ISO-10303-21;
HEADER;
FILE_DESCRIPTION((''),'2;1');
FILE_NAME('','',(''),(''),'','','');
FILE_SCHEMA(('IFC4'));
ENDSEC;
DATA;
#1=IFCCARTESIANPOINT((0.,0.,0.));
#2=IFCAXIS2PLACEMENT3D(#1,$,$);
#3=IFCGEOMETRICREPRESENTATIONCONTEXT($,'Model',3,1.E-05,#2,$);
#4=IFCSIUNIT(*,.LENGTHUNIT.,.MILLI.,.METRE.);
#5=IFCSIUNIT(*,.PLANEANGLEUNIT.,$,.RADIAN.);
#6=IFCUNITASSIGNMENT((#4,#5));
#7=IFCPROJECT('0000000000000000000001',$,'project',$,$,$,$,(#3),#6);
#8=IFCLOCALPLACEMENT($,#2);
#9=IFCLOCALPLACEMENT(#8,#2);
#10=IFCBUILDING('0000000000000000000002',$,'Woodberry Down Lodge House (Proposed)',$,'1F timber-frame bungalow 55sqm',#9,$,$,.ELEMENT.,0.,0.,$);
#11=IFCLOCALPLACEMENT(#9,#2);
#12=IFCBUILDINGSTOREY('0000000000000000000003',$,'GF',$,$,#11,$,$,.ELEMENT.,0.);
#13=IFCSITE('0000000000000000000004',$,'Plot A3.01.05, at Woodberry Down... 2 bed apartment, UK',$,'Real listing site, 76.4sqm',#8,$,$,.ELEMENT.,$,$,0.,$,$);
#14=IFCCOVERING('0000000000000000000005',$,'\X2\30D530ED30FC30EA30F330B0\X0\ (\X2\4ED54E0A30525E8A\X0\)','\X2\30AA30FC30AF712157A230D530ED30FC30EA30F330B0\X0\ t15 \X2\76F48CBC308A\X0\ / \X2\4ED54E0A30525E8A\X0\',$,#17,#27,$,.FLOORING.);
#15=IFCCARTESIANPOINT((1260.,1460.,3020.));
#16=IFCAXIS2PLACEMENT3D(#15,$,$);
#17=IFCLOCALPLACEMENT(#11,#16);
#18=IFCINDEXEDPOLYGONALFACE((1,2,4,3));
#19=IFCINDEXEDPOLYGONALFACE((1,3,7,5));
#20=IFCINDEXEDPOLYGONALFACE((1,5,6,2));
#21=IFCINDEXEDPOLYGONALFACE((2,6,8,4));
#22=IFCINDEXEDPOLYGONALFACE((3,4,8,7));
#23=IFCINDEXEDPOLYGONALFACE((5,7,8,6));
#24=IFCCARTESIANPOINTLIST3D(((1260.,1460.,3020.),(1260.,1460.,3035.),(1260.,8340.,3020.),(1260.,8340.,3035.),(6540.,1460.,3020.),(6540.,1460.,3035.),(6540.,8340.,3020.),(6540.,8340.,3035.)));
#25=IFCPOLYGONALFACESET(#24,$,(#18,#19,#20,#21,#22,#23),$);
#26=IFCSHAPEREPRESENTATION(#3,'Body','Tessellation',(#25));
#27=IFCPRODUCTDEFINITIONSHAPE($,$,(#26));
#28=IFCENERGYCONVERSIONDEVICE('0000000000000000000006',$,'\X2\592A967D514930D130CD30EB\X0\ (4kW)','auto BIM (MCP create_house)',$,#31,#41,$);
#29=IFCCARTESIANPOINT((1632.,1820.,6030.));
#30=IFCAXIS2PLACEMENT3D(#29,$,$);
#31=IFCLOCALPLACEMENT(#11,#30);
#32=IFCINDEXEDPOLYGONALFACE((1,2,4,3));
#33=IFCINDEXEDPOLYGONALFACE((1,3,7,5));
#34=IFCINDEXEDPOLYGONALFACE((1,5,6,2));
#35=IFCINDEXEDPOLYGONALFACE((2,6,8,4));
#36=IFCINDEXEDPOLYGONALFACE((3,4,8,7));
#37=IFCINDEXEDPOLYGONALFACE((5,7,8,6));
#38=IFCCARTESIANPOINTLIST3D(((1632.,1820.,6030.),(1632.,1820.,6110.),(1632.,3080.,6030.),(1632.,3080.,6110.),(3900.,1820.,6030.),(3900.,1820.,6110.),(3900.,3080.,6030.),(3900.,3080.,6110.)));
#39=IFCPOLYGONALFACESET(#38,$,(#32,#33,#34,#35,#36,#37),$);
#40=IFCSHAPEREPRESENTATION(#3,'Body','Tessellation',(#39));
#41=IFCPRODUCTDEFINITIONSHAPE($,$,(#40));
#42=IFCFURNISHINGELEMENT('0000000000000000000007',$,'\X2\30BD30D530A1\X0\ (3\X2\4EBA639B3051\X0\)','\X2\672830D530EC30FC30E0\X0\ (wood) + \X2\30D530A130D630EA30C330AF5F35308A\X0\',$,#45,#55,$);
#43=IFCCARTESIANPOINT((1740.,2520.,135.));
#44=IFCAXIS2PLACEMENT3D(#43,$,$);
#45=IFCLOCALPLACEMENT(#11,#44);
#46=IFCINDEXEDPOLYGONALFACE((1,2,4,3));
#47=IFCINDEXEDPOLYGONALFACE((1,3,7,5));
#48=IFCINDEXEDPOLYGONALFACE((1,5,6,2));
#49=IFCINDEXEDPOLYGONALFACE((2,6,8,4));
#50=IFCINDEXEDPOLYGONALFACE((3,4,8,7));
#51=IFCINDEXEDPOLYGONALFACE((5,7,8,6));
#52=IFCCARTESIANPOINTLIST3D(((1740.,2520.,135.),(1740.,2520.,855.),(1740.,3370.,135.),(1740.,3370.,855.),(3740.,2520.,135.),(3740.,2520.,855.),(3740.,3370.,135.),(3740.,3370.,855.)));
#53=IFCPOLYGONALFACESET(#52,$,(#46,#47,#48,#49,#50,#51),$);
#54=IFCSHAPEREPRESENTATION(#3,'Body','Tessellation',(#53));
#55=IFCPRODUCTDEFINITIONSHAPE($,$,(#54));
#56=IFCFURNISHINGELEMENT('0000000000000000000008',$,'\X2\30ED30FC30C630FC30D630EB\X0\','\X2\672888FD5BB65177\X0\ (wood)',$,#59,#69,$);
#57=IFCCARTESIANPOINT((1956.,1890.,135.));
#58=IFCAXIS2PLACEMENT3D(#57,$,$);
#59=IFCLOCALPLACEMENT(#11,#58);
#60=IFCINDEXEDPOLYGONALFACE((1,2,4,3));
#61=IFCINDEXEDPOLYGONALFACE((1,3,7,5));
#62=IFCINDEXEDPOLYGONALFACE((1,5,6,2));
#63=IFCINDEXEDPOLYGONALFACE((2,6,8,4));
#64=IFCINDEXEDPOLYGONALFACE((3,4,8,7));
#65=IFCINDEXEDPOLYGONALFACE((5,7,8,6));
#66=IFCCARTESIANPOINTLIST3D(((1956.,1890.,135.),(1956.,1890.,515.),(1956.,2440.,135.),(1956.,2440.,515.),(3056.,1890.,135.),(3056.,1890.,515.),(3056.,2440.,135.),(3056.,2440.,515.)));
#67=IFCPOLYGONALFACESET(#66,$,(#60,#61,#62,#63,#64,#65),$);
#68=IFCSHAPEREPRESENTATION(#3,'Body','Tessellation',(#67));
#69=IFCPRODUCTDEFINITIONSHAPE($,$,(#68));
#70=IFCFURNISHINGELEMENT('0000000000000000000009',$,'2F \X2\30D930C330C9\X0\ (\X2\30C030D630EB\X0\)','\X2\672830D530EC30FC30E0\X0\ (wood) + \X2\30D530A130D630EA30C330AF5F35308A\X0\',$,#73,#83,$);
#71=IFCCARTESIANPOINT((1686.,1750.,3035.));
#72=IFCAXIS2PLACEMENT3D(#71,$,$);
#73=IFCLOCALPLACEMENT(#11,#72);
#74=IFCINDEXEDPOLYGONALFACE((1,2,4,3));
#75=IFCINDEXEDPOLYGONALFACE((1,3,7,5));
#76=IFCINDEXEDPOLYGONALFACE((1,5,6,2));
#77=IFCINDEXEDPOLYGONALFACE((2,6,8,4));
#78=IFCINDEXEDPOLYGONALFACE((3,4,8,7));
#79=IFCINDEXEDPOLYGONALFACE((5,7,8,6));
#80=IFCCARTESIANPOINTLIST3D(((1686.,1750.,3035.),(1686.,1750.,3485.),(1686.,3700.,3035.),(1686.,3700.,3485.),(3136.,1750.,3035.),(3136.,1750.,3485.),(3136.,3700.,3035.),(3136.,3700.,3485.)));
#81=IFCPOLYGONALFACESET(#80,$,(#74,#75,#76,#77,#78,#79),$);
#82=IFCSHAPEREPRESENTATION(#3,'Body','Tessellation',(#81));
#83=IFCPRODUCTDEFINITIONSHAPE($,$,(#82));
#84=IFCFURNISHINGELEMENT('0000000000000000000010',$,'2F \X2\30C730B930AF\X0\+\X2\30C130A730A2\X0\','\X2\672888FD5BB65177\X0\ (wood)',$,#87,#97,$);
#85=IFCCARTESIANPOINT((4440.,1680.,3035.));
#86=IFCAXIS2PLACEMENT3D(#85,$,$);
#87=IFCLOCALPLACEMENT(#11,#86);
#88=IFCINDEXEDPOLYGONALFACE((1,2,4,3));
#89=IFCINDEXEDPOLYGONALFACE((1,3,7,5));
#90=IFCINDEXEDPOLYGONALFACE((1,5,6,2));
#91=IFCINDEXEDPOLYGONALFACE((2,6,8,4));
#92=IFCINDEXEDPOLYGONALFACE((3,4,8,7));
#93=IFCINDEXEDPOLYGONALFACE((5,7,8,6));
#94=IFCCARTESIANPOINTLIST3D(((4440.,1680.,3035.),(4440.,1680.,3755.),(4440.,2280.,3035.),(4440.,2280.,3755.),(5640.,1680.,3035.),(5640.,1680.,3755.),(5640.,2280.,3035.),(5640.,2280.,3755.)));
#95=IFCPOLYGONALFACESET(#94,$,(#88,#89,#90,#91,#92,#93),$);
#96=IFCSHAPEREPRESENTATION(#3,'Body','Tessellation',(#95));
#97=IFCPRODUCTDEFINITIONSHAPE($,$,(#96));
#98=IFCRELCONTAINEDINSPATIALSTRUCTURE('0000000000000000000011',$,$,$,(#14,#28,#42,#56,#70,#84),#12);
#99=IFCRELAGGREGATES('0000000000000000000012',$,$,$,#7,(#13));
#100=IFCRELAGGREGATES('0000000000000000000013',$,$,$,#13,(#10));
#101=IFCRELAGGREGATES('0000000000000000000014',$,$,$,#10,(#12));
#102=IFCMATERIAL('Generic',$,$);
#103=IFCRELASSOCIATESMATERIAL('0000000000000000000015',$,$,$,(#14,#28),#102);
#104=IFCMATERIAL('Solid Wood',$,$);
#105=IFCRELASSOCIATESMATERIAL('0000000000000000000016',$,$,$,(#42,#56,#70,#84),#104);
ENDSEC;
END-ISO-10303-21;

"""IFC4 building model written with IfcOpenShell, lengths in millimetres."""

from ifc_helpers import new_model, si_unit, frame, frame_2d, origin, place, context, project, spatial, rectangle, extrude, material, element, save


model = new_model("IFC4")

# Units and contexts
model_context = context("Model", 3, precision=1e-05, world=origin())
ifc_project = project(units=[si_unit("LENGTHUNIT", "METRE", prefix="MILLI"), si_unit("PLANEANGLEUNIT", "RADIAN")], contexts=[model_context])

# Site, building, storey
site_placement = place(None, origin())
site = spatial("IfcSite", under=ifc_project, at=site_placement, Name="Plot A3.01.05, at Woodberry Down... 2 bed apartment, UK", ObjectType="Real listing site, 76.4sqm", CompositionType="ELEMENT", RefElevation=0.0)
building_placement = place(site_placement, origin())
building = spatial("IfcBuilding", under=site, at=building_placement, Name="Woodberry Down Lodge House (Proposed)", ObjectType="1F timber-frame bungalow 55sqm", CompositionType="ELEMENT", ElevationOfRefHeight=0.0, ElevationOfTerrain=0.0)
storey_placement = place(building_placement, origin())
storey = spatial("IfcBuildingStorey", under=building, at=storey_placement, Name="GF", CompositionType="ELEMENT", Elevation=0.0)

# Shared definitions
ifc_material_1 = material(Name="Solid Wood")

# Shared definitions
ifc_material_2 = material(Name="Generic")

# Covering
covering_placement = place(storey_placement, frame((1260.0, 1460.0, 3020.0)))
element("IfcCovering", 1, at=covering_placement, inside=storey, material=ifc_material_2, Name="フローリング (仕上げ床)", Description="オーク無垢フローリング t15 直貼り / 仕上げ床", PredefinedType="FLOORING", context=model_context, shape_type="SweptSolid", body=[
    extrude(rectangle(XDim=5280.0, YDim=6880.0, at=frame_2d((2640.0, 3440.0))), frame((1260.0, 1460.0, 3020.0)), (0.0, 0.0, 1.0), 15.0),
])

# Energy conversion device
energy_conversion_device_placement = place(storey_placement, frame((1632.0, 1820.0, 6030.0)))
element("IfcEnergyConversionDevice", 2, at=energy_conversion_device_placement, inside=storey, material=ifc_material_2, Name="太陽光パネル (4kW)", Description="auto BIM (MCP create_house)", context=model_context, shape_type="SweptSolid", body=[
    extrude(rectangle(XDim=2268.0, YDim=1260.0, at=frame_2d((1134.0, 630.0))), frame((1632.0, 1820.0, 6030.0)), (0.0, 0.0, 1.0), 80.0),
])

# Furnishing elements
furnishing_1_placement = place(storey_placement, frame((1740.0, 2520.0, 135.0)))
element("IfcFurnishingElement", 3, at=furnishing_1_placement, inside=storey, material=ifc_material_1, Name="ソファ (3人掛け)", Description="木フレーム (wood) + ファブリック張り", context=model_context, shape_type="SweptSolid", body=[
    extrude(rectangle(XDim=2000.0, YDim=850.0, at=frame_2d((1000.0, 425.0))), frame((1740.0, 2520.0, 135.0)), (0.0, 0.0, 1.0), 720.0),
])
furnishing_2_placement = place(storey_placement, frame((1956.0, 1890.0, 135.0)))
element("IfcFurnishingElement", 4, at=furnishing_2_placement, inside=storey, material=ifc_material_1, Name="ローテーブル", Description="木製家具 (wood)", context=model_context, shape_type="SweptSolid", body=[
    extrude(rectangle(XDim=1100.0, YDim=550.0, at=frame_2d((550.0, 275.0))), frame((1956.0, 1890.0, 135.0)), (0.0, 0.0, 1.0), 380.0),
])
furnishing_3_placement = place(storey_placement, frame((1686.0, 1750.0, 3035.0)))
element("IfcFurnishingElement", 5, at=furnishing_3_placement, inside=storey, material=ifc_material_1, Name="2F ベッド (ダブル)", Description="木フレーム (wood) + ファブリック張り", context=model_context, shape_type="SweptSolid", body=[
    extrude(rectangle(XDim=1450.0, YDim=1950.0, at=frame_2d((725.0, 975.0))), frame((1686.0, 1750.0, 3035.0)), (0.0, 0.0, 1.0), 450.0),
])
furnishing_4_placement = place(storey_placement, frame((4440.0, 1680.0, 3035.0)))
element("IfcFurnishingElement", 6, at=furnishing_4_placement, inside=storey, material=ifc_material_1, Name="2F デスク+チェア", Description="木製家具 (wood)", context=model_context, shape_type="SweptSolid", body=[
    extrude(rectangle(XDim=1200.0, YDim=600.0, at=frame_2d((600.0, 300.0))), frame((4440.0, 1680.0, 3035.0)), (0.0, 0.0, 1.0), 720.0),
])

save(model, "model.ifc")
